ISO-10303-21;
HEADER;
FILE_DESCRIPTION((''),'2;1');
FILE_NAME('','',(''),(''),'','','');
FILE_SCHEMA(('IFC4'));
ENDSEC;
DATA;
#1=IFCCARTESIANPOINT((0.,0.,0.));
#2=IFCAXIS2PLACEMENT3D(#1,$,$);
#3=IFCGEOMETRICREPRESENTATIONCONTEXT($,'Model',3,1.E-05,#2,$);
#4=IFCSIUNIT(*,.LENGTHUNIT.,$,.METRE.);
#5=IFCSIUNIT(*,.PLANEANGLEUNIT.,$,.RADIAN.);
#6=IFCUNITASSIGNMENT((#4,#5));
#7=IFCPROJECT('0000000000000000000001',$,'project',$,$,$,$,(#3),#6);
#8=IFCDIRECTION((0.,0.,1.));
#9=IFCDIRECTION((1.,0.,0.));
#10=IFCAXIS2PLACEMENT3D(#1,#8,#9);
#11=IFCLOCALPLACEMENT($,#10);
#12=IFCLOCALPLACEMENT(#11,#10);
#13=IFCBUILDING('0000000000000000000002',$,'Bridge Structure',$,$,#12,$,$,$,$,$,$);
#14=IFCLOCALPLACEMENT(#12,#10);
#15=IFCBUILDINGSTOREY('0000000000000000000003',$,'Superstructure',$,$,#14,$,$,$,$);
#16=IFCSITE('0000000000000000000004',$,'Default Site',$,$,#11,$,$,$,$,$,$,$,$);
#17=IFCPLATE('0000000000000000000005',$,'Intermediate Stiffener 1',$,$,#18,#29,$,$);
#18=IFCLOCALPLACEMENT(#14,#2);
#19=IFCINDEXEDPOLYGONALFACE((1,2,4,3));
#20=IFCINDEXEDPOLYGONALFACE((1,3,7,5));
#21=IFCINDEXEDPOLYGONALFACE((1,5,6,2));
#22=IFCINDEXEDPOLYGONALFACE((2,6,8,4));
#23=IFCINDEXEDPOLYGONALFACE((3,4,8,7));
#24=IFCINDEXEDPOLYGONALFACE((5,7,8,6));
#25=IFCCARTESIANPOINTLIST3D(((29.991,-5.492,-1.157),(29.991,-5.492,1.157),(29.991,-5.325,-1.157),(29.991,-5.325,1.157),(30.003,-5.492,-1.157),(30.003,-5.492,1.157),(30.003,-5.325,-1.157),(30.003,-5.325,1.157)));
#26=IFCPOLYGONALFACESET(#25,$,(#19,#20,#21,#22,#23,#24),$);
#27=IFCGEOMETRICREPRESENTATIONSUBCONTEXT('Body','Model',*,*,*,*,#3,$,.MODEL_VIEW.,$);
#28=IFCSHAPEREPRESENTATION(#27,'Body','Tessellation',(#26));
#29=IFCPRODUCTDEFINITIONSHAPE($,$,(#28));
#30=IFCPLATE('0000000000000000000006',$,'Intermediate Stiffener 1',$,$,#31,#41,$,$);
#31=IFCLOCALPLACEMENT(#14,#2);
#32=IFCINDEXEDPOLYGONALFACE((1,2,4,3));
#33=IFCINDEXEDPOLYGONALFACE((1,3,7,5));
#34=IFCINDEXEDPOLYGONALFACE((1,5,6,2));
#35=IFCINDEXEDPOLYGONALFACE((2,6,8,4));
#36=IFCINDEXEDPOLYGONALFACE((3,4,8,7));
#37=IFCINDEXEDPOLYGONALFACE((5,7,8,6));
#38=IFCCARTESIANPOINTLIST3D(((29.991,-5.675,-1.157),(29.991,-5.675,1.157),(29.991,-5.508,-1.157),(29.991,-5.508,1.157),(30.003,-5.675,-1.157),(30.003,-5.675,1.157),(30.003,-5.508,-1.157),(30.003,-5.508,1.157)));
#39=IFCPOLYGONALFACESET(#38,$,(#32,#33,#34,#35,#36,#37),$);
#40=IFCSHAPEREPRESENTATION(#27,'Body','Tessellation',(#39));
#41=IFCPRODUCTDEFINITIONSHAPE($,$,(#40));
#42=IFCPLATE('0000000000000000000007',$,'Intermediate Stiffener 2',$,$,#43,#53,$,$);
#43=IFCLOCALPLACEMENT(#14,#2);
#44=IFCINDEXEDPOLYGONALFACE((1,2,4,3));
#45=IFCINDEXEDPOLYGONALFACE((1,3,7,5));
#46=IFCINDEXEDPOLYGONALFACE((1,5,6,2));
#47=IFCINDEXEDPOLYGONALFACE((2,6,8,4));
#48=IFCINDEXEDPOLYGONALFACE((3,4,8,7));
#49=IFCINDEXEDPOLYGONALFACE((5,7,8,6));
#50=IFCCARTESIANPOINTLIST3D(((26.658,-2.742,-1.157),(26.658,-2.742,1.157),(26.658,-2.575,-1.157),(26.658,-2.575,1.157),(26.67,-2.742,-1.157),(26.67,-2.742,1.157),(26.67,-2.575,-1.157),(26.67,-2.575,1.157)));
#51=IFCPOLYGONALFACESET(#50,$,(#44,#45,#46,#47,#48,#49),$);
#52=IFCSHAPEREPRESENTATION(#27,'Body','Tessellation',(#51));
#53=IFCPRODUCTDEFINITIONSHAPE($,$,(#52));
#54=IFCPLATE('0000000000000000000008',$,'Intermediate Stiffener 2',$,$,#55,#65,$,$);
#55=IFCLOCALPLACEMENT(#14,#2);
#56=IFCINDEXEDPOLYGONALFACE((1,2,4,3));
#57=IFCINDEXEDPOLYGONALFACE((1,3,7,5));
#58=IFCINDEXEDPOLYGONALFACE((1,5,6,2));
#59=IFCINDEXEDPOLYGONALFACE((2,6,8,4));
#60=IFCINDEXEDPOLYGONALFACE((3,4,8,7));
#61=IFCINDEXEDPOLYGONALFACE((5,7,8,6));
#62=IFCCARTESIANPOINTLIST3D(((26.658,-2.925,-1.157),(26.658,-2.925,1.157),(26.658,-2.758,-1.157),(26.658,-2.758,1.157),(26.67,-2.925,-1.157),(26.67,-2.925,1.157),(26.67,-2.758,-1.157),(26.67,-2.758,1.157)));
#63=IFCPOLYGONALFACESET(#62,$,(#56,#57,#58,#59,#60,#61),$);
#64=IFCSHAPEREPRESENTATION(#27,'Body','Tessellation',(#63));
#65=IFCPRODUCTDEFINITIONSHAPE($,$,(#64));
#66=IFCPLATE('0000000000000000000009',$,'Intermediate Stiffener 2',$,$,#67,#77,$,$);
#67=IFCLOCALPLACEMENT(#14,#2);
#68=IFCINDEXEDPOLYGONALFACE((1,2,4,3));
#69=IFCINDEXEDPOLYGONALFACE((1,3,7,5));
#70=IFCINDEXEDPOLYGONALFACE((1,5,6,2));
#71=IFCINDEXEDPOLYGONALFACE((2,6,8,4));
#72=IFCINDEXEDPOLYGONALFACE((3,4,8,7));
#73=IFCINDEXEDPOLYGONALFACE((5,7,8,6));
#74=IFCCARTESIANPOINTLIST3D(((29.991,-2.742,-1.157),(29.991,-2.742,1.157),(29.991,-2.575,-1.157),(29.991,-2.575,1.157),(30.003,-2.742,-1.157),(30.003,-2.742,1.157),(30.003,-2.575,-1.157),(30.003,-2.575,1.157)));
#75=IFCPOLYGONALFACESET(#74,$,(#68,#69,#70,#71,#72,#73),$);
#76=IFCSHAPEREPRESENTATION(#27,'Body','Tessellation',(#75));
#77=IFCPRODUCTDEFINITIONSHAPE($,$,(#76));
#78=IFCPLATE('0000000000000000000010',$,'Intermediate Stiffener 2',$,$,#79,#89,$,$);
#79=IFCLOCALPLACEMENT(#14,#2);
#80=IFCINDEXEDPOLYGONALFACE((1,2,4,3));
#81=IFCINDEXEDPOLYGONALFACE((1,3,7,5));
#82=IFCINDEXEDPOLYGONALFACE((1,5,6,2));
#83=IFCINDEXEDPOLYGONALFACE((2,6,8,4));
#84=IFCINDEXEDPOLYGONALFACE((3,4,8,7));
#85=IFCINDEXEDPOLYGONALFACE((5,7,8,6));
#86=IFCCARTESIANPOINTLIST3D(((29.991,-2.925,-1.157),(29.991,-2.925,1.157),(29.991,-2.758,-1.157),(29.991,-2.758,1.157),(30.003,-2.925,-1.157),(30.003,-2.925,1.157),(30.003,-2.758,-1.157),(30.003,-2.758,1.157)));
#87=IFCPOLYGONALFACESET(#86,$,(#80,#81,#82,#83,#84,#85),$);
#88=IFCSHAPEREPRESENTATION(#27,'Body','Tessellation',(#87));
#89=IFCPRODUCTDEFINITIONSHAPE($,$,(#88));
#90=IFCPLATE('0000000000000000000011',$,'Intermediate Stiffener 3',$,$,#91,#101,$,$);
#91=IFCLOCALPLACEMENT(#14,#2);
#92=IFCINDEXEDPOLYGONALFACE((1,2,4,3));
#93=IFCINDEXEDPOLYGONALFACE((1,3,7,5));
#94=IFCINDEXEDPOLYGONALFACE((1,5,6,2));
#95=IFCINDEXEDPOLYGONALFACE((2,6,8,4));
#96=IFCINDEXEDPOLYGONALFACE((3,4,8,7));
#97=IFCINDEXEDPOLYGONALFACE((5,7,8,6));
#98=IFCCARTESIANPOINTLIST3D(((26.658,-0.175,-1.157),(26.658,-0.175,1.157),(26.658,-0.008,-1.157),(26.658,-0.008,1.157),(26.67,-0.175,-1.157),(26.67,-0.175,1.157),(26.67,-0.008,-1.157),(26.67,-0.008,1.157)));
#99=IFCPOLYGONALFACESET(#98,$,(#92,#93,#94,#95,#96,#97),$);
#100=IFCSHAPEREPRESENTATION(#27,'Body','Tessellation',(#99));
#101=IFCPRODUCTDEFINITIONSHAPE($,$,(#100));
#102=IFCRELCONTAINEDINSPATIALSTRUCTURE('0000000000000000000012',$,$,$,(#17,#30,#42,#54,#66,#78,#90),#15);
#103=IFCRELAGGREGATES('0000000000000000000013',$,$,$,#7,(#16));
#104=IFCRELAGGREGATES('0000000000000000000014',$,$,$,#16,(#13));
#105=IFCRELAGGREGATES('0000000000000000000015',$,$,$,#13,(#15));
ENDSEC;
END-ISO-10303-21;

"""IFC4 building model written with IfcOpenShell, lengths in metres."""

from ifc_helpers import new_model, si_unit, frame, origin, origin_with_axes, origin_2d_with_axis, place, context, subcontext, project, spatial, rectangle, extrude, element, save


model = new_model("IFC4")

# Units and contexts
model_context = context("Model", 3, precision=1e-05, world=origin())
body_context = subcontext(model_context, "Body", "Model", "MODEL_VIEW")
ifc_project = project(units=[si_unit("LENGTHUNIT", "METRE"), si_unit("PLANEANGLEUNIT", "RADIAN")], contexts=[model_context])

# Site, building, storey
site_placement = place(None, origin_with_axes())
site = spatial("IfcSite", under=ifc_project, at=site_placement, Name="Default Site")
building_placement = place(site_placement, origin_with_axes())
building = spatial("IfcBuilding", under=site, at=building_placement, Name="Bridge Structure")
storey_placement = place(building_placement, origin_with_axes())
storey = spatial("IfcBuildingStorey", under=building, at=storey_placement, Name="Superstructure")

# Plates
for number, where, z_axis, x_axis, name in (
    (1, (29.997, -5.4085, -1.157), (0.0, 0.0, 1.0), (1.0, 0.0, 0.0), "Intermediate Stiffener 1"),
    (2, (29.997, -5.5915, -1.157), (0.0, 0.0, 1.0), (1.0, 0.0, 0.0), "Intermediate Stiffener 1"),
    (3, (26.664, -2.6585, -1.157), (0.0, 0.0, 1.0), (1.0, 0.0, 0.0), "Intermediate Stiffener 2"),
    (4, (26.664, -2.8415, -1.157), (0.0, 0.0, 1.0), (1.0, 0.0, 0.0), "Intermediate Stiffener 2"),
    (5, (29.997, -2.6585, -1.157), (0.0, 0.0, 1.0), (1.0, 0.0, 0.0), "Intermediate Stiffener 2"),
    (6, (29.997, -2.8415, -1.157), (0.0, 0.0, 1.0), (1.0, 0.0, 0.0), "Intermediate Stiffener 2"),
    (7, (26.664, -0.0915, -1.157), (0.0, 0.0, 1.0), (1.0, 0.0, 0.0), "Intermediate Stiffener 3"),
):
    element("IfcPlate", number, at=place(storey_placement, frame(where, z_axis=z_axis, x_axis=x_axis)), inside=storey, Name=name, context=body_context, shape_type="SweptSolid", body=[
        extrude(rectangle(XDim=0.012, YDim=0.167, at=origin_2d_with_axis()), origin_with_axes(), (0.0, 0.0, 1.0), 2.314),
    ])

save(model, "model.ifc")
